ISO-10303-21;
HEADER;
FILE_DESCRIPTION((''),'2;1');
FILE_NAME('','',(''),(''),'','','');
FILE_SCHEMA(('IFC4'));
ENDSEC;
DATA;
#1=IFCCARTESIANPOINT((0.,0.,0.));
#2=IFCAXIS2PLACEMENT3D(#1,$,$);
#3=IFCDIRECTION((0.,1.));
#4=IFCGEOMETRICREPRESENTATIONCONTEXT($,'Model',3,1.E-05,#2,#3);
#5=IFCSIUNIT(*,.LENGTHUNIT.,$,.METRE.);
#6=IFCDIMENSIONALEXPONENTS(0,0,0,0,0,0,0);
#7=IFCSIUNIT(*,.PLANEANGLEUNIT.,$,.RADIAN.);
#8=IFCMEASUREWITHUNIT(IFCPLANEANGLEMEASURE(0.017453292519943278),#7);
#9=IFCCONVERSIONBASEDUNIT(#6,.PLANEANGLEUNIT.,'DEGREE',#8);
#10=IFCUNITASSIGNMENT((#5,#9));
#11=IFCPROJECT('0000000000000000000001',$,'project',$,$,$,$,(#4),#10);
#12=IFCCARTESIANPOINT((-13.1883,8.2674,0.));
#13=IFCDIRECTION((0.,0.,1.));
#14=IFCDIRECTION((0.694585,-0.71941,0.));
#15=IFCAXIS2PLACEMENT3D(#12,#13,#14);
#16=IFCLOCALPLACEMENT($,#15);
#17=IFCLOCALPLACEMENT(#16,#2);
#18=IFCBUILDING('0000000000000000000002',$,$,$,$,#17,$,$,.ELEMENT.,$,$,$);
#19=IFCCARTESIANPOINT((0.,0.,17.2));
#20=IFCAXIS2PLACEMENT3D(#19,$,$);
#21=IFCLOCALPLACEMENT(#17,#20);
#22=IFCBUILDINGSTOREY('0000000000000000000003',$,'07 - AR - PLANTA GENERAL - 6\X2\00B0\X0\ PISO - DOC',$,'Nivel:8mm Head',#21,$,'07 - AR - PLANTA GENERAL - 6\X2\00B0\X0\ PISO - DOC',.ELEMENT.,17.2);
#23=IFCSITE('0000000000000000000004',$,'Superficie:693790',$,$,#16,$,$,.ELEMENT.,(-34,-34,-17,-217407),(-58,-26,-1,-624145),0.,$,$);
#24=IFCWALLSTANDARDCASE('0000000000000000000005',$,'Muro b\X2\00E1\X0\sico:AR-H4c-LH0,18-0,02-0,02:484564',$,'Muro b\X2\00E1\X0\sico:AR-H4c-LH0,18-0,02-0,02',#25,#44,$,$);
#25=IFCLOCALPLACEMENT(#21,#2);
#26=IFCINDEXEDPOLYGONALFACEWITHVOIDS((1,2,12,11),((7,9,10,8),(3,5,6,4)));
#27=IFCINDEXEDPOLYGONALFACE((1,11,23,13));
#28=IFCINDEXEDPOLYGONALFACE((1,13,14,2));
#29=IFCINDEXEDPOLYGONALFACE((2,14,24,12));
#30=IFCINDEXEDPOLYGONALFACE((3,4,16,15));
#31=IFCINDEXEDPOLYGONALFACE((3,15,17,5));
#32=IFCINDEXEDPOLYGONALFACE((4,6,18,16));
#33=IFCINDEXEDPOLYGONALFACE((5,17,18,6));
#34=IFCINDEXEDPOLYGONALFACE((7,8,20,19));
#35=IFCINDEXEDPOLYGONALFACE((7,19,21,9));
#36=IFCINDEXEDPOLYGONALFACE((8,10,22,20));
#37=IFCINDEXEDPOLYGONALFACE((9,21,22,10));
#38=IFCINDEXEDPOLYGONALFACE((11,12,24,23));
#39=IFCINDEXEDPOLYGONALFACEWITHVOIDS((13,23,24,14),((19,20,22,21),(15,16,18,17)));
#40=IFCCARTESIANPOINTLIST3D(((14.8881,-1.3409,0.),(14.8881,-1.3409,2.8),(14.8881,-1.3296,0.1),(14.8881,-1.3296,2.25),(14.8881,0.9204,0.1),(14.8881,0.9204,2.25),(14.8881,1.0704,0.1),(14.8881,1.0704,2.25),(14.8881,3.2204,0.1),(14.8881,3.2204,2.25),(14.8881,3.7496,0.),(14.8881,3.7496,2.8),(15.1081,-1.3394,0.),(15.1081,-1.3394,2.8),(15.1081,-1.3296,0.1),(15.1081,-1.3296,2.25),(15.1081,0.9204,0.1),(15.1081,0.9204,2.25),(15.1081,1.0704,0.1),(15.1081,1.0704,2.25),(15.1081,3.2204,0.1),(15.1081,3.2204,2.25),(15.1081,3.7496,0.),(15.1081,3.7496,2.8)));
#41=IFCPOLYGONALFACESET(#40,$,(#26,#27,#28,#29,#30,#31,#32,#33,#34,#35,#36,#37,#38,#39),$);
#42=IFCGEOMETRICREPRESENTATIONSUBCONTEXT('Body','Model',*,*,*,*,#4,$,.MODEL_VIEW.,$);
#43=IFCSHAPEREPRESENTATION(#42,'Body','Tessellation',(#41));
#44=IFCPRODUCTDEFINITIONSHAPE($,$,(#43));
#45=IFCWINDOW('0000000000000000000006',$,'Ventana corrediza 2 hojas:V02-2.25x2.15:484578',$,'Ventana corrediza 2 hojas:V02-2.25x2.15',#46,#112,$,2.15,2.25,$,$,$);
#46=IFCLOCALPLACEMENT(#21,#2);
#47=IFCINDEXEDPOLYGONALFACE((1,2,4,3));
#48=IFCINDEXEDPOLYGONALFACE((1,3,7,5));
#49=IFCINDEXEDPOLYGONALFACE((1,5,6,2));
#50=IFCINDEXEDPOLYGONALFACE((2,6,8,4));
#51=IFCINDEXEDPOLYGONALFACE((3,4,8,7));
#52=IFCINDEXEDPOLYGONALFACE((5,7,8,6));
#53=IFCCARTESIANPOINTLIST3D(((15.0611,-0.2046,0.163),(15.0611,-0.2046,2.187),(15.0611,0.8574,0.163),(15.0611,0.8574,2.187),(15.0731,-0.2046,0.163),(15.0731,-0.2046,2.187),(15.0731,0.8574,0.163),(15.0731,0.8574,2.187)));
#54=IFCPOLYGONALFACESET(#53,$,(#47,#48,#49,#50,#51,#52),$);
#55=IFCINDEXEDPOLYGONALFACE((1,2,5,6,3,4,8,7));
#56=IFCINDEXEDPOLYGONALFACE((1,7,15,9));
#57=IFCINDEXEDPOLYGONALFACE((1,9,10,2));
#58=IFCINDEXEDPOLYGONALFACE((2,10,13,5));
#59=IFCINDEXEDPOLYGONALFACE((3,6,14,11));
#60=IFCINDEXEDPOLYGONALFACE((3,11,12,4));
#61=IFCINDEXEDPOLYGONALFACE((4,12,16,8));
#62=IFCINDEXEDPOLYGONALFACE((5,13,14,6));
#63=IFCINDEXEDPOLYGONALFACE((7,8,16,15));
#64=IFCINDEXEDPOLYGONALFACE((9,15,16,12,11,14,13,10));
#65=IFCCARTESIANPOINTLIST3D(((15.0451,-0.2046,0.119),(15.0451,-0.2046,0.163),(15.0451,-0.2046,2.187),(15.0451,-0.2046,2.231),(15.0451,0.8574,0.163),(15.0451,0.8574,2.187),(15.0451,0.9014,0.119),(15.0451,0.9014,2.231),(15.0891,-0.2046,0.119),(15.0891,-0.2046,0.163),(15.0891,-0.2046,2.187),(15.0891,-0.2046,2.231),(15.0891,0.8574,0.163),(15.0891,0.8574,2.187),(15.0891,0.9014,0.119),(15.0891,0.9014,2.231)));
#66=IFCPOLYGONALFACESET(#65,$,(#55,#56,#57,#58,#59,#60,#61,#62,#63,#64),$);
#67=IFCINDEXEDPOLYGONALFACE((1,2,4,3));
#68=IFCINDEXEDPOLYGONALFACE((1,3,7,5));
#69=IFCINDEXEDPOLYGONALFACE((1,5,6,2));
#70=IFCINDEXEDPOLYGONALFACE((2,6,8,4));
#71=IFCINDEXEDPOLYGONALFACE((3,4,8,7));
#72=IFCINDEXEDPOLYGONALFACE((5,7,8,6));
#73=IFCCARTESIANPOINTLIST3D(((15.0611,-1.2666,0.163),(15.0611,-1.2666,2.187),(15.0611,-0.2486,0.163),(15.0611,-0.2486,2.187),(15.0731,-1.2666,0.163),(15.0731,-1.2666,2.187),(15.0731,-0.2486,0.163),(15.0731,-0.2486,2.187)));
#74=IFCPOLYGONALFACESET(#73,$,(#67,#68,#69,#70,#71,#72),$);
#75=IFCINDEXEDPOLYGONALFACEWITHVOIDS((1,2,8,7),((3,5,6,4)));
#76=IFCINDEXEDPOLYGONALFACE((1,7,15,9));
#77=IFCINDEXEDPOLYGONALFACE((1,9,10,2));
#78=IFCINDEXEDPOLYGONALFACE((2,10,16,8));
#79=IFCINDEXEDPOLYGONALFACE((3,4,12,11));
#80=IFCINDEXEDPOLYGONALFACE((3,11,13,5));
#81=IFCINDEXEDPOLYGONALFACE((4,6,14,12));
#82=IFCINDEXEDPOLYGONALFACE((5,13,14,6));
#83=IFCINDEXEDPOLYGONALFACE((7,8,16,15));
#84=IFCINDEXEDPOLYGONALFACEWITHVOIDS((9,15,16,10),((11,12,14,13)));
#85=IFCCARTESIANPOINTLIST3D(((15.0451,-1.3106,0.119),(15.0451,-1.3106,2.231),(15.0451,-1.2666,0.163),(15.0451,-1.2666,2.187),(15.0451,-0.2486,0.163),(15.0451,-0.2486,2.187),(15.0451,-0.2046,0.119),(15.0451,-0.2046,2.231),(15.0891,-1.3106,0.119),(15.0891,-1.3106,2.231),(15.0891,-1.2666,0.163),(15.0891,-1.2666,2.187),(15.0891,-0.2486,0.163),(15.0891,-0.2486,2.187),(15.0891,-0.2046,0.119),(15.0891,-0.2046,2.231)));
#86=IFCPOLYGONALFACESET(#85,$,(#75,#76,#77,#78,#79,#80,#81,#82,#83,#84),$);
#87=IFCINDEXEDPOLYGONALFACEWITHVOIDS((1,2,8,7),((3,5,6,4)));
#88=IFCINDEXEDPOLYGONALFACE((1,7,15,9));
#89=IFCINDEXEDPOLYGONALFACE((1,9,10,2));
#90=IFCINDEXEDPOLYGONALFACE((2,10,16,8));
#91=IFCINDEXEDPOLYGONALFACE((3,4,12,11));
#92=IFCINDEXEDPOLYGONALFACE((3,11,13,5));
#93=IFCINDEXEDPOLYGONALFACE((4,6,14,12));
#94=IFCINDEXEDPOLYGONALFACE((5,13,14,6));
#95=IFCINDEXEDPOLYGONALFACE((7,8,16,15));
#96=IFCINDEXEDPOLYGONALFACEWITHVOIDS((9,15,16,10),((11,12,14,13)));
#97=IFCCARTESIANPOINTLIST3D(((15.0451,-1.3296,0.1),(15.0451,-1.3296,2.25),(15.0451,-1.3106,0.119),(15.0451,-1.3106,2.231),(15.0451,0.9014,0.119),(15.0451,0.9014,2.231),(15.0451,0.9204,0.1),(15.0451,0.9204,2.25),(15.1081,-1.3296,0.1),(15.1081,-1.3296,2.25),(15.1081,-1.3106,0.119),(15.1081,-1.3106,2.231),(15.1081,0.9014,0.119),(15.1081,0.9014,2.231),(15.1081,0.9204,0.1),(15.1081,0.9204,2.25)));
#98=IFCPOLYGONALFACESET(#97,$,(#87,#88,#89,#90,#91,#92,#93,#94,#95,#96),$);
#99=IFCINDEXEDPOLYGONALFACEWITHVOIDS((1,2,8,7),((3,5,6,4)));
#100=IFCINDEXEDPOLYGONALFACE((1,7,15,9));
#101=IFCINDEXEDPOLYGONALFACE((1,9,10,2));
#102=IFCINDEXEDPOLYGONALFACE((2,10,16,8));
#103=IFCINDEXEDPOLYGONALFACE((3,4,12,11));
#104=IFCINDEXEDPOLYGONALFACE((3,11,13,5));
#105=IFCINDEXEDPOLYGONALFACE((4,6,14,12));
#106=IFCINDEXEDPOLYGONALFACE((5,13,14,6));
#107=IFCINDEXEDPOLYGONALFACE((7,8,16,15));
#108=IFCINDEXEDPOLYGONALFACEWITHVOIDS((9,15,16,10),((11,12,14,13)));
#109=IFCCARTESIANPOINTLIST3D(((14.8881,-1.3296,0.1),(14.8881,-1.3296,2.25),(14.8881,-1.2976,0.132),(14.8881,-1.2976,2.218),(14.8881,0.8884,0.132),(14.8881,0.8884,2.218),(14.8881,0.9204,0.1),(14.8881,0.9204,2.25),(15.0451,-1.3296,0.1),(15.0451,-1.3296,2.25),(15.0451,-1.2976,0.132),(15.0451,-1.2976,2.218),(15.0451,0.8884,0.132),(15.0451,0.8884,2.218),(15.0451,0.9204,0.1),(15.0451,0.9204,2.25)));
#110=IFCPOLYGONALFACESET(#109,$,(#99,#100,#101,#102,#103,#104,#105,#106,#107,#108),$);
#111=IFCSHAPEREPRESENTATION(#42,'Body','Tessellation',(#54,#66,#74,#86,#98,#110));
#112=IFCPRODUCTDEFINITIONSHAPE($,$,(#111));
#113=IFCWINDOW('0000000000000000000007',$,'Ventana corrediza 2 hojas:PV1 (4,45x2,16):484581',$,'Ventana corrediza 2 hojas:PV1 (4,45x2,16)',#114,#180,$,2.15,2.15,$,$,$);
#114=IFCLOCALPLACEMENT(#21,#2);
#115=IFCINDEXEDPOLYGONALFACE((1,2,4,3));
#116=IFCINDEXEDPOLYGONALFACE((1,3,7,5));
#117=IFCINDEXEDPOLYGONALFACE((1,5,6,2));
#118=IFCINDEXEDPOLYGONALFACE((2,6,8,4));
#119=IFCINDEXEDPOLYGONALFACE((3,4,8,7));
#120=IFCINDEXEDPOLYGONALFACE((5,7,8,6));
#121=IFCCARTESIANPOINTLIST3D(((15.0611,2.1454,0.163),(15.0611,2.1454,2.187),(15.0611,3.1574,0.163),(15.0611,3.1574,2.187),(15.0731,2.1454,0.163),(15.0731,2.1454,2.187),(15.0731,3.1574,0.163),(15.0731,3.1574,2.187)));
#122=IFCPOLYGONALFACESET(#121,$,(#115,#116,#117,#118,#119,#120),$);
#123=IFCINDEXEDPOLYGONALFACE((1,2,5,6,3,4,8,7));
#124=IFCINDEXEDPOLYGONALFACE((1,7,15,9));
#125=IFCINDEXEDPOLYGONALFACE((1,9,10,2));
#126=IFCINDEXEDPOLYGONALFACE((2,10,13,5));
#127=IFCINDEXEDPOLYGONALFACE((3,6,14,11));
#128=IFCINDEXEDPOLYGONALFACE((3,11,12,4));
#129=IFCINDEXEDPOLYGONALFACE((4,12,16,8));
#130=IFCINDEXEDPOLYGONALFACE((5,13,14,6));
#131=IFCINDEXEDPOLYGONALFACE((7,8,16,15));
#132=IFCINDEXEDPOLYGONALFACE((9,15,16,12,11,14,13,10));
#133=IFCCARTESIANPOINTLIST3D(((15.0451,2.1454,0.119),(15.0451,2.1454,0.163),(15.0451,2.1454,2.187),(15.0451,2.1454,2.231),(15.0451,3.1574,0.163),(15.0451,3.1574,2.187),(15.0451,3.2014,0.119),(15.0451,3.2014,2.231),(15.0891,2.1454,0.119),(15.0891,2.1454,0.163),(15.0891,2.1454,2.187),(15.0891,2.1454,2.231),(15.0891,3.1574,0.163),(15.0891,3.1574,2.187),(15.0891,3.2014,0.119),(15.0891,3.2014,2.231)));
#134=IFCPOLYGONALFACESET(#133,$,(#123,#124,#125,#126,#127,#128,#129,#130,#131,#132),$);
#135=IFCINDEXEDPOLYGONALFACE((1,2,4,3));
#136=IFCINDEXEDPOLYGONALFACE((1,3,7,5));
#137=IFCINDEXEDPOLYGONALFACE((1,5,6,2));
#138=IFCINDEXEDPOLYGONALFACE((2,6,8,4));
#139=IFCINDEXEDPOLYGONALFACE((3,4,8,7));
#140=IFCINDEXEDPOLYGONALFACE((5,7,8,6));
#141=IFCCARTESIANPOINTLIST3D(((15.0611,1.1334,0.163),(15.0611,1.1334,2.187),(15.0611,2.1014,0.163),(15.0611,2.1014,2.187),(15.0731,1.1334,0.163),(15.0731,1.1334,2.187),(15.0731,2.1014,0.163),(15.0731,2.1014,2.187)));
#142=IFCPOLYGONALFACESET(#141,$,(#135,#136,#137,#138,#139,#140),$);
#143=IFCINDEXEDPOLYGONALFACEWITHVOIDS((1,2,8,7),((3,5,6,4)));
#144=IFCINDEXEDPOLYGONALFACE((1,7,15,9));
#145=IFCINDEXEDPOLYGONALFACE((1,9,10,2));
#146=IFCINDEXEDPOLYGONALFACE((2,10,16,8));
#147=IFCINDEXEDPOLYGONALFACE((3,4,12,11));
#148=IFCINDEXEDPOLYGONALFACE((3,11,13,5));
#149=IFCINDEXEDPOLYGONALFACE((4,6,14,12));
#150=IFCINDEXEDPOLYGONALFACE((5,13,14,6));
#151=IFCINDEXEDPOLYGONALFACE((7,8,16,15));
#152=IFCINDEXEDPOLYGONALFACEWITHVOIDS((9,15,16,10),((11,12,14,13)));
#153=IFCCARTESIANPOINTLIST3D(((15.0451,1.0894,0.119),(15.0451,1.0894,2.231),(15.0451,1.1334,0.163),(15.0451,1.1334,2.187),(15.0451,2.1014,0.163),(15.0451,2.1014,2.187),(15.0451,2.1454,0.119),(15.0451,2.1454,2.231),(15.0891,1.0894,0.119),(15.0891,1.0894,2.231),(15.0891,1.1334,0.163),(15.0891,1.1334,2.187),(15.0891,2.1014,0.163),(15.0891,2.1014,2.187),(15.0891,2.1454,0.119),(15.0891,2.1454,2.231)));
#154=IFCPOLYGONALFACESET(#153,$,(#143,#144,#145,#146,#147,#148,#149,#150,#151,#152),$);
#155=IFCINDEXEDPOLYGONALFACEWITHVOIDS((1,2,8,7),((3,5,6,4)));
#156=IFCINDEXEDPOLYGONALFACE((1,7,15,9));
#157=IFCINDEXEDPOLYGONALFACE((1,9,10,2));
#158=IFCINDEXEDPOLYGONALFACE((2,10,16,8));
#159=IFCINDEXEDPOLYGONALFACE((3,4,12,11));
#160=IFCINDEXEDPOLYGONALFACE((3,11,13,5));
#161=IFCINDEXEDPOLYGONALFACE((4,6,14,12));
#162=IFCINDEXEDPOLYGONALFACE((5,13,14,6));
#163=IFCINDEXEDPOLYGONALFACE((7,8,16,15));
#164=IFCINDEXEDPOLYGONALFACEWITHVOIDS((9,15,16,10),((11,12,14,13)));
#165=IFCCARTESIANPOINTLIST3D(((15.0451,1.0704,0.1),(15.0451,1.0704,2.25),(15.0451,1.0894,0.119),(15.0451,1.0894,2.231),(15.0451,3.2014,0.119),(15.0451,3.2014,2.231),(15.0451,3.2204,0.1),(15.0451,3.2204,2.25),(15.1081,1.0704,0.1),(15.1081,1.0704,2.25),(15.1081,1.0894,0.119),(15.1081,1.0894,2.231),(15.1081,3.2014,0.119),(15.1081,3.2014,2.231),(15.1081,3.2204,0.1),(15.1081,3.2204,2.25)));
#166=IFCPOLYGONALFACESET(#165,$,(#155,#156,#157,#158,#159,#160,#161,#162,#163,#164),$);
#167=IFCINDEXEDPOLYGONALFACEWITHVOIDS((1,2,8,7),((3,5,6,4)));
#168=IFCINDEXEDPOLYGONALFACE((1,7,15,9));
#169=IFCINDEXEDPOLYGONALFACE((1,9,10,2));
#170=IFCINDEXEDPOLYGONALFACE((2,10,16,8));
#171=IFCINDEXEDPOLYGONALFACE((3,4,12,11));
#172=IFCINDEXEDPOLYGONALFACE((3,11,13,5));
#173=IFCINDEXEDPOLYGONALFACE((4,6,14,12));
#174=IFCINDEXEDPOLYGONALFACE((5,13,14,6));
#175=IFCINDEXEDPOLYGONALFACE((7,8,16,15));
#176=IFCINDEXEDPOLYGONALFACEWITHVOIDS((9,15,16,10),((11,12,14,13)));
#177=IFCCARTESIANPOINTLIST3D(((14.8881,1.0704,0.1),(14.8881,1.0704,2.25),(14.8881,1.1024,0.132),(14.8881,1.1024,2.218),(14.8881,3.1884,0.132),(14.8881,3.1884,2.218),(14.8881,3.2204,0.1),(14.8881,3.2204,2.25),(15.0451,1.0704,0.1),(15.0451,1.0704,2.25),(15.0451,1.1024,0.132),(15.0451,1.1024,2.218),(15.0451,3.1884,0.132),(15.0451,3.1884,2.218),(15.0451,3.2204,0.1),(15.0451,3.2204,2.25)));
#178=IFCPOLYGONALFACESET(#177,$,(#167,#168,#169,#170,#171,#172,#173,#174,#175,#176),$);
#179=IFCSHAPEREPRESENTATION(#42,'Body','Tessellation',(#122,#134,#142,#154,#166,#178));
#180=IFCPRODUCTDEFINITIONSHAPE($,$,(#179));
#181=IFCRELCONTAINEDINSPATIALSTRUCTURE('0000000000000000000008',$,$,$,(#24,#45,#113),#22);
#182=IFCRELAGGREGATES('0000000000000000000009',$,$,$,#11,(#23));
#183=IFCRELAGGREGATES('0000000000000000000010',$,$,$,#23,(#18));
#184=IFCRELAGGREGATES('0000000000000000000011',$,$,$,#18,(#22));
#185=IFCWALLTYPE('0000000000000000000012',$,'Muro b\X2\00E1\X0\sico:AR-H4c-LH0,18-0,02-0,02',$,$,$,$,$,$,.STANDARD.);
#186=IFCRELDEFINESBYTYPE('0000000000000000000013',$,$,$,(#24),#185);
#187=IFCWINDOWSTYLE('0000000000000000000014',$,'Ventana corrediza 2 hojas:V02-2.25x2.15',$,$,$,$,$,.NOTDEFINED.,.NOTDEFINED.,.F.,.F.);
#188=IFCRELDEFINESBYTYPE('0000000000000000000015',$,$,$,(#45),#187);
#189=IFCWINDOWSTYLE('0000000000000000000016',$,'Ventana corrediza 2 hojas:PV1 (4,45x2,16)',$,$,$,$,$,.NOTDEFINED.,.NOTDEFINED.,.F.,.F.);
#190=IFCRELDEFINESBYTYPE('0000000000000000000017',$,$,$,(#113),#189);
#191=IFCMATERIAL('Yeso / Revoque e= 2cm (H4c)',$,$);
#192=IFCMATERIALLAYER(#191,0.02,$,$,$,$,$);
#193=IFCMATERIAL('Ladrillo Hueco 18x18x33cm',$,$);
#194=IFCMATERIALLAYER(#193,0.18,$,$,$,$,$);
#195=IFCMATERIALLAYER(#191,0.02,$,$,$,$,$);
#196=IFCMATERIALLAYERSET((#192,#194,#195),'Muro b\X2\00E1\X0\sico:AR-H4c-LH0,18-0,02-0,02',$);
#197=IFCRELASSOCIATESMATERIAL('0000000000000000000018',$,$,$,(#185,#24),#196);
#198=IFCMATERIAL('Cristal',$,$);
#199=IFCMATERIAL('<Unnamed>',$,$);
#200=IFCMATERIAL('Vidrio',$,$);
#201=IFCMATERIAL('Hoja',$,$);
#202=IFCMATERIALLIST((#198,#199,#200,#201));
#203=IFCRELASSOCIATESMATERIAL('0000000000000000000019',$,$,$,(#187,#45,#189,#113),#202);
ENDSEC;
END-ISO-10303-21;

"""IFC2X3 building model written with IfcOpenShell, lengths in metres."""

from ifc_helpers import new_model, entity, si_unit, converted_unit, direction, frame, frame_2d, origin, place, context, subcontext, project, spatial, polyline, rectangle, outline, extrude, source, transform, mapped, material, material_list, layer, layer_set, layer_usage, type_object, type_shapes, element, fill, save


model = new_model("IFC2X3")

# Units and contexts
model_context = context("Model", 3, precision=1e-05, world=origin(), true_north=direction((0.0, 1.0)))
body_context = subcontext(model_context, "Body", "Model", "MODEL_VIEW")
ifc_project = project(units=[si_unit("LENGTHUNIT", "METRE"), converted_unit("PLANEANGLEUNIT", "DEGREE", entity("IfcPlaneAngleMeasure", 0.017453292519943278), si_unit("PLANEANGLEUNIT", "RADIAN"), dimensions=[0, 0, 0, 0, 0, 0, 0])], contexts=[model_context])

# Site, building, storey
site_placement = place(None, frame((-13.1883, 8.2674, 0.0), z_axis=(0.0, 0.0, 1.0), x_axis=(0.694585, -0.71941, 0.0)))
site = spatial("IfcSite", under=ifc_project, at=site_placement, Name="Superficie:693790", CompositionType="ELEMENT", RefLatitude=(-34, -34, -17, -217407), RefLongitude=(-58, -26, -1, -624145), RefElevation=0.0)
building_placement = place(site_placement, origin())
building = spatial("IfcBuilding", under=site, at=building_placement, CompositionType="ELEMENT")
storey_placement = place(building_placement, frame((0.0, 0.0, 17.2)))
storey = spatial("IfcBuildingStorey", under=building, at=storey_placement, Name="07 - AR - PLANTA GENERAL - 6° PISO - DOC", ObjectType="Nivel:8mm Head", LongName="07 - AR - PLANTA GENERAL - 6° PISO - DOC", CompositionType="ELEMENT", Elevation=17.2)

# Shared definitions
ifc_material_1 = material(Name="Yeso / Revoque e= 2cm (H4c)")
ifc_layer_1 = layer(ifc_material_1, 0.02)
ifc_material_2 = material(Name="Ladrillo Hueco 18x18x33cm")
ifc_layer_2 = layer(ifc_material_2, 0.18)
ifc_layer_3 = layer(ifc_material_1, 0.02)
ifc_layer_set_1 = layer_set([ifc_layer_1, ifc_layer_2, ifc_layer_3], Name="Muro básico:AR-H4c-LH0,18-0,02-0,02")
wall_type_1 = type_object("IfcWallType", Name="Muro básico:AR-H4c-LH0,18-0,02-0,02", PredefinedType="STANDARD", material=ifc_layer_set_1)
ifc_material_3 = material(Name="Cristal")
ifc_material_4 = material(Name="<Unnamed>")
ifc_material_5 = material(Name="Vidrio")
ifc_material_6 = material(Name="Hoja")
ifc_material_list = material_list([ifc_material_3, ifc_material_4, ifc_material_5, ifc_material_6])

# Wall, openings, windows
ifc_layer_usage_1 = layer_usage(ifc_layer_set_1, "AXIS2", "NEGATIVE", 0.11)
wall_1_placement = place(storey_placement, frame((14.9981, 3.7496, 0.0), z_axis=(0.0, 0.0, 1.0), x_axis=(0.0, -1.0, 0.0)))
wall_1 = element("IfcWallStandardCase", 1, at=wall_1_placement, inside=storey, type_object=wall_type_1, material=ifc_layer_usage_1, Name="Muro básico:AR-H4c-LH0,18-0,02-0,02:484564", ObjectType="Muro básico:AR-H4c-LH0,18-0,02-0,02", context=body_context, shape_type="SweptSolid", body=[
    extrude(outline(polyline([(5.0905, -0.11), (5.0893, 0.0645), (5.089, 0.11), (0.0, 0.11), (0.0, -0.11), (0.0042, -0.11), (0.1542, -0.11), (5.0705, -0.11), (5.0905, -0.11)])), origin(), (0.0, 0.0, 1.0), 2.8),
])
opening_1_placement = place(wall_1_placement, frame((0.5292, -0.11, 0.1)))
opening_1 = element("IfcOpeningElement", 2, at=opening_1_placement, cuts=wall_1, ObjectType="Opening", context=body_context, shape_type="SweptSolid", body=[
    extrude(rectangle(XDim=2.15, YDim=2.15, at=frame_2d((1.075, 1.075), x_axis=(1.0, 0.0))), frame((0.0, 0.0, 0.0), z_axis=(0.0, 1.0, 0.0), x_axis=(0.0, 0.0, 1.0)), (0.0, 0.0, 1.0), 0.22),
])
opening_2_placement = place(wall_1_placement, frame((2.8292, -0.11, 0.1)))
opening_2 = element("IfcOpeningElement", 3, at=opening_2_placement, cuts=wall_1, ObjectType="Opening", context=body_context, shape_type="SweptSolid", body=[
    extrude(rectangle(XDim=2.15, YDim=2.25, at=frame_2d((1.075, 1.125), x_axis=(1.0, 0.0))), frame((0.0, 0.0, 0.0), z_axis=(0.0, 1.0, 0.0), x_axis=(0.0, 0.0, 1.0)), (0.0, 0.0, 1.0), 0.22),
])
window_style_1 = type_object("IfcWindowStyle", Name="Ventana corrediza 2 hojas:V02-2.25x2.15", ConstructionType="NOTDEFINED", OperationType="NOTDEFINED", ParameterTakesPrecedence=False, Sizeable=False, material=ifc_material_list)
shared_shape_1 = source(origin(), body_context, "Body", "SweptSolid", [
    extrude(rectangle(XDim=0.012, YDim=1.062, at=frame_2d((0.0, 0.0), x_axis=(1.0, 0.0))), frame((0.594, 0.179, 0.063), z_axis=(0.0, 0.0, 1.0), x_axis=(0.0, -1.0, 0.0)), (0.0, 0.0, 1.0), 2.024),
    extrude(outline(polyline([(-0.564, -1.056), (0.542, -1.056), (0.542, -1.012), (-0.52, -1.012), (-0.52, 1.012), (0.542, 1.012), (0.542, 1.056), (-0.564, 1.056), (-0.564, -1.056)])), frame((0.583, 0.157, 1.075), z_axis=(0.0, 1.0, 0.0), x_axis=(1.0, 0.0, 0.0)), (0.0, 0.0, 1.0), 0.044),
    extrude(rectangle(XDim=0.012, YDim=1.018, at=frame_2d((0.0, 0.0), x_axis=(1.0, 0.0))), frame((1.678, 0.179, 0.063), z_axis=(0.0, 0.0, 1.0), x_axis=(0.0, -1.0, 0.0)), (0.0, 0.0, 1.0), 2.024),
    extrude(outline(polyline([(-0.553, -1.056), (0.553, -1.056), (0.553, 1.056), (-0.553, 1.056), (-0.553, -1.056)]), holes=[polyline([(-0.509, -1.012), (-0.509, 1.012), (0.509, 1.012), (0.509, -1.012), (-0.509, -1.012)])]), frame((1.678, 0.157, 1.075), z_axis=(0.0, 1.0, 0.0), x_axis=(1.0, 0.0, 0.0)), (0.0, 0.0, 1.0), 0.044),
    extrude(outline(polyline([(-1.125, -1.075), (1.125, -1.075), (1.125, 1.075), (-1.125, 1.075), (-1.125, -1.075)]), holes=[polyline([(-1.106, -1.056), (-1.106, 1.056), (1.106, 1.056), (1.106, -1.056), (-1.106, -1.056)])]), frame((1.125, 0.157, 1.075), z_axis=(0.0, 1.0, 0.0), x_axis=(1.0, 0.0, 0.0)), (0.0, 0.0, 1.0), 0.063),
    extrude(outline(polyline([(-1.125, -1.075), (1.125, -1.075), (1.125, 1.075), (-1.125, 1.075), (-1.125, -1.075)]), holes=[polyline([(-1.093, -1.043), (-1.093, 1.043), (1.093, 1.043), (1.093, -1.043), (-1.093, -1.043)])]), frame((1.125, 0.0, 1.075), z_axis=(0.0, 1.0, 0.0), x_axis=(1.0, 0.0, 0.0)), (0.0, 0.0, 1.0), 0.157),
])
type_shapes(window_style_1, [shared_shape_1])
window_1_placement = place(opening_2_placement, origin())
window_1 = element("IfcWindow", 4, at=window_1_placement, inside=storey, type_object=window_style_1, material=ifc_material_list, Name="Ventana corrediza 2 hojas:V02-2.25x2.15:484578", ObjectType="Ventana corrediza 2 hojas:V02-2.25x2.15", OverallHeight=2.15, OverallWidth=2.25, context=body_context, shape_type="MappedRepresentation", body=[
    mapped(shared_shape_1, transform((0.0, 0.0, 0.0), scale=1.0)),
])
fill(opening_2, window_1)
window_style_2 = type_object("IfcWindowStyle", Name="Ventana corrediza 2 hojas:PV1 (4,45x2,16)", ConstructionType="NOTDEFINED", OperationType="NOTDEFINED", ParameterTakesPrecedence=False, Sizeable=False, material=ifc_material_list)
shared_shape_2 = source(origin(), body_context, "Body", "SweptSolid", [
    extrude(rectangle(XDim=0.012, YDim=1.012, at=frame_2d((0.0, 0.0), x_axis=(1.0, 0.0))), frame((0.569, 0.179, 0.063), z_axis=(0.0, 0.0, 1.0), x_axis=(0.0, -1.0, 0.0)), (0.0, 0.0, 1.0), 2.024),
    extrude(outline(polyline([(-0.539, -1.056), (0.517, -1.056), (0.517, -1.012), (-0.495, -1.012), (-0.495, 1.012), (0.517, 1.012), (0.517, 1.056), (-0.539, 1.056), (-0.539, -1.056)])), frame((0.558, 0.157, 1.075), z_axis=(0.0, 1.0, 0.0), x_axis=(1.0, 0.0, 0.0)), (0.0, 0.0, 1.0), 0.044),
    extrude(rectangle(XDim=0.012, YDim=0.968, at=frame_2d((0.0, 0.0), x_axis=(1.0, 0.0))), frame((1.603, 0.179, 0.063), z_axis=(0.0, 0.0, 1.0), x_axis=(0.0, -1.0, 0.0)), (0.0, 0.0, 1.0), 2.024),
    extrude(outline(polyline([(-0.528, -1.056), (0.528, -1.056), (0.528, 1.056), (-0.528, 1.056), (-0.528, -1.056)]), holes=[polyline([(-0.484, -1.012), (-0.484, 1.012), (0.484, 1.012), (0.484, -1.012), (-0.484, -1.012)])]), frame((1.603, 0.157, 1.075), z_axis=(0.0, 1.0, 0.0), x_axis=(1.0, 0.0, 0.0)), (0.0, 0.0, 1.0), 0.044),
    extrude(outline(polyline([(-1.075, -1.075), (1.075, -1.075), (1.075, 1.075), (-1.075, 1.075), (-1.075, -1.075)]), holes=[polyline([(-1.056, -1.056), (-1.056, 1.056), (1.056, 1.056), (1.056, -1.056), (-1.056, -1.056)])]), frame((1.075, 0.157, 1.075), z_axis=(0.0, 1.0, 0.0), x_axis=(1.0, 0.0, 0.0)), (0.0, 0.0, 1.0), 0.063),
    extrude(outline(polyline([(-1.075, -1.075), (1.075, -1.075), (1.075, 1.075), (-1.075, 1.075), (-1.075, -1.075)]), holes=[polyline([(-1.043, -1.043), (-1.043, 1.043), (1.043, 1.043), (1.043, -1.043), (-1.043, -1.043)])]), frame((1.075, 0.0, 1.075), z_axis=(0.0, 1.0, 0.0), x_axis=(1.0, 0.0, 0.0)), (0.0, 0.0, 1.0), 0.157),
])
type_shapes(window_style_2, [shared_shape_2])
window_2_placement = place(opening_1_placement, origin())
window_2 = element("IfcWindow", 5, at=window_2_placement, inside=storey, type_object=window_style_2, material=ifc_material_list, Name="Ventana corrediza 2 hojas:PV1 (4,45x2,16):484581", ObjectType="Ventana corrediza 2 hojas:PV1 (4,45x2,16)", OverallHeight=2.15, OverallWidth=2.15, context=body_context, shape_type="MappedRepresentation", body=[
    mapped(shared_shape_2, transform((0.0, 0.0, 0.0), scale=1.0)),
])
fill(opening_1, window_2)

save(model, "model.ifc")
